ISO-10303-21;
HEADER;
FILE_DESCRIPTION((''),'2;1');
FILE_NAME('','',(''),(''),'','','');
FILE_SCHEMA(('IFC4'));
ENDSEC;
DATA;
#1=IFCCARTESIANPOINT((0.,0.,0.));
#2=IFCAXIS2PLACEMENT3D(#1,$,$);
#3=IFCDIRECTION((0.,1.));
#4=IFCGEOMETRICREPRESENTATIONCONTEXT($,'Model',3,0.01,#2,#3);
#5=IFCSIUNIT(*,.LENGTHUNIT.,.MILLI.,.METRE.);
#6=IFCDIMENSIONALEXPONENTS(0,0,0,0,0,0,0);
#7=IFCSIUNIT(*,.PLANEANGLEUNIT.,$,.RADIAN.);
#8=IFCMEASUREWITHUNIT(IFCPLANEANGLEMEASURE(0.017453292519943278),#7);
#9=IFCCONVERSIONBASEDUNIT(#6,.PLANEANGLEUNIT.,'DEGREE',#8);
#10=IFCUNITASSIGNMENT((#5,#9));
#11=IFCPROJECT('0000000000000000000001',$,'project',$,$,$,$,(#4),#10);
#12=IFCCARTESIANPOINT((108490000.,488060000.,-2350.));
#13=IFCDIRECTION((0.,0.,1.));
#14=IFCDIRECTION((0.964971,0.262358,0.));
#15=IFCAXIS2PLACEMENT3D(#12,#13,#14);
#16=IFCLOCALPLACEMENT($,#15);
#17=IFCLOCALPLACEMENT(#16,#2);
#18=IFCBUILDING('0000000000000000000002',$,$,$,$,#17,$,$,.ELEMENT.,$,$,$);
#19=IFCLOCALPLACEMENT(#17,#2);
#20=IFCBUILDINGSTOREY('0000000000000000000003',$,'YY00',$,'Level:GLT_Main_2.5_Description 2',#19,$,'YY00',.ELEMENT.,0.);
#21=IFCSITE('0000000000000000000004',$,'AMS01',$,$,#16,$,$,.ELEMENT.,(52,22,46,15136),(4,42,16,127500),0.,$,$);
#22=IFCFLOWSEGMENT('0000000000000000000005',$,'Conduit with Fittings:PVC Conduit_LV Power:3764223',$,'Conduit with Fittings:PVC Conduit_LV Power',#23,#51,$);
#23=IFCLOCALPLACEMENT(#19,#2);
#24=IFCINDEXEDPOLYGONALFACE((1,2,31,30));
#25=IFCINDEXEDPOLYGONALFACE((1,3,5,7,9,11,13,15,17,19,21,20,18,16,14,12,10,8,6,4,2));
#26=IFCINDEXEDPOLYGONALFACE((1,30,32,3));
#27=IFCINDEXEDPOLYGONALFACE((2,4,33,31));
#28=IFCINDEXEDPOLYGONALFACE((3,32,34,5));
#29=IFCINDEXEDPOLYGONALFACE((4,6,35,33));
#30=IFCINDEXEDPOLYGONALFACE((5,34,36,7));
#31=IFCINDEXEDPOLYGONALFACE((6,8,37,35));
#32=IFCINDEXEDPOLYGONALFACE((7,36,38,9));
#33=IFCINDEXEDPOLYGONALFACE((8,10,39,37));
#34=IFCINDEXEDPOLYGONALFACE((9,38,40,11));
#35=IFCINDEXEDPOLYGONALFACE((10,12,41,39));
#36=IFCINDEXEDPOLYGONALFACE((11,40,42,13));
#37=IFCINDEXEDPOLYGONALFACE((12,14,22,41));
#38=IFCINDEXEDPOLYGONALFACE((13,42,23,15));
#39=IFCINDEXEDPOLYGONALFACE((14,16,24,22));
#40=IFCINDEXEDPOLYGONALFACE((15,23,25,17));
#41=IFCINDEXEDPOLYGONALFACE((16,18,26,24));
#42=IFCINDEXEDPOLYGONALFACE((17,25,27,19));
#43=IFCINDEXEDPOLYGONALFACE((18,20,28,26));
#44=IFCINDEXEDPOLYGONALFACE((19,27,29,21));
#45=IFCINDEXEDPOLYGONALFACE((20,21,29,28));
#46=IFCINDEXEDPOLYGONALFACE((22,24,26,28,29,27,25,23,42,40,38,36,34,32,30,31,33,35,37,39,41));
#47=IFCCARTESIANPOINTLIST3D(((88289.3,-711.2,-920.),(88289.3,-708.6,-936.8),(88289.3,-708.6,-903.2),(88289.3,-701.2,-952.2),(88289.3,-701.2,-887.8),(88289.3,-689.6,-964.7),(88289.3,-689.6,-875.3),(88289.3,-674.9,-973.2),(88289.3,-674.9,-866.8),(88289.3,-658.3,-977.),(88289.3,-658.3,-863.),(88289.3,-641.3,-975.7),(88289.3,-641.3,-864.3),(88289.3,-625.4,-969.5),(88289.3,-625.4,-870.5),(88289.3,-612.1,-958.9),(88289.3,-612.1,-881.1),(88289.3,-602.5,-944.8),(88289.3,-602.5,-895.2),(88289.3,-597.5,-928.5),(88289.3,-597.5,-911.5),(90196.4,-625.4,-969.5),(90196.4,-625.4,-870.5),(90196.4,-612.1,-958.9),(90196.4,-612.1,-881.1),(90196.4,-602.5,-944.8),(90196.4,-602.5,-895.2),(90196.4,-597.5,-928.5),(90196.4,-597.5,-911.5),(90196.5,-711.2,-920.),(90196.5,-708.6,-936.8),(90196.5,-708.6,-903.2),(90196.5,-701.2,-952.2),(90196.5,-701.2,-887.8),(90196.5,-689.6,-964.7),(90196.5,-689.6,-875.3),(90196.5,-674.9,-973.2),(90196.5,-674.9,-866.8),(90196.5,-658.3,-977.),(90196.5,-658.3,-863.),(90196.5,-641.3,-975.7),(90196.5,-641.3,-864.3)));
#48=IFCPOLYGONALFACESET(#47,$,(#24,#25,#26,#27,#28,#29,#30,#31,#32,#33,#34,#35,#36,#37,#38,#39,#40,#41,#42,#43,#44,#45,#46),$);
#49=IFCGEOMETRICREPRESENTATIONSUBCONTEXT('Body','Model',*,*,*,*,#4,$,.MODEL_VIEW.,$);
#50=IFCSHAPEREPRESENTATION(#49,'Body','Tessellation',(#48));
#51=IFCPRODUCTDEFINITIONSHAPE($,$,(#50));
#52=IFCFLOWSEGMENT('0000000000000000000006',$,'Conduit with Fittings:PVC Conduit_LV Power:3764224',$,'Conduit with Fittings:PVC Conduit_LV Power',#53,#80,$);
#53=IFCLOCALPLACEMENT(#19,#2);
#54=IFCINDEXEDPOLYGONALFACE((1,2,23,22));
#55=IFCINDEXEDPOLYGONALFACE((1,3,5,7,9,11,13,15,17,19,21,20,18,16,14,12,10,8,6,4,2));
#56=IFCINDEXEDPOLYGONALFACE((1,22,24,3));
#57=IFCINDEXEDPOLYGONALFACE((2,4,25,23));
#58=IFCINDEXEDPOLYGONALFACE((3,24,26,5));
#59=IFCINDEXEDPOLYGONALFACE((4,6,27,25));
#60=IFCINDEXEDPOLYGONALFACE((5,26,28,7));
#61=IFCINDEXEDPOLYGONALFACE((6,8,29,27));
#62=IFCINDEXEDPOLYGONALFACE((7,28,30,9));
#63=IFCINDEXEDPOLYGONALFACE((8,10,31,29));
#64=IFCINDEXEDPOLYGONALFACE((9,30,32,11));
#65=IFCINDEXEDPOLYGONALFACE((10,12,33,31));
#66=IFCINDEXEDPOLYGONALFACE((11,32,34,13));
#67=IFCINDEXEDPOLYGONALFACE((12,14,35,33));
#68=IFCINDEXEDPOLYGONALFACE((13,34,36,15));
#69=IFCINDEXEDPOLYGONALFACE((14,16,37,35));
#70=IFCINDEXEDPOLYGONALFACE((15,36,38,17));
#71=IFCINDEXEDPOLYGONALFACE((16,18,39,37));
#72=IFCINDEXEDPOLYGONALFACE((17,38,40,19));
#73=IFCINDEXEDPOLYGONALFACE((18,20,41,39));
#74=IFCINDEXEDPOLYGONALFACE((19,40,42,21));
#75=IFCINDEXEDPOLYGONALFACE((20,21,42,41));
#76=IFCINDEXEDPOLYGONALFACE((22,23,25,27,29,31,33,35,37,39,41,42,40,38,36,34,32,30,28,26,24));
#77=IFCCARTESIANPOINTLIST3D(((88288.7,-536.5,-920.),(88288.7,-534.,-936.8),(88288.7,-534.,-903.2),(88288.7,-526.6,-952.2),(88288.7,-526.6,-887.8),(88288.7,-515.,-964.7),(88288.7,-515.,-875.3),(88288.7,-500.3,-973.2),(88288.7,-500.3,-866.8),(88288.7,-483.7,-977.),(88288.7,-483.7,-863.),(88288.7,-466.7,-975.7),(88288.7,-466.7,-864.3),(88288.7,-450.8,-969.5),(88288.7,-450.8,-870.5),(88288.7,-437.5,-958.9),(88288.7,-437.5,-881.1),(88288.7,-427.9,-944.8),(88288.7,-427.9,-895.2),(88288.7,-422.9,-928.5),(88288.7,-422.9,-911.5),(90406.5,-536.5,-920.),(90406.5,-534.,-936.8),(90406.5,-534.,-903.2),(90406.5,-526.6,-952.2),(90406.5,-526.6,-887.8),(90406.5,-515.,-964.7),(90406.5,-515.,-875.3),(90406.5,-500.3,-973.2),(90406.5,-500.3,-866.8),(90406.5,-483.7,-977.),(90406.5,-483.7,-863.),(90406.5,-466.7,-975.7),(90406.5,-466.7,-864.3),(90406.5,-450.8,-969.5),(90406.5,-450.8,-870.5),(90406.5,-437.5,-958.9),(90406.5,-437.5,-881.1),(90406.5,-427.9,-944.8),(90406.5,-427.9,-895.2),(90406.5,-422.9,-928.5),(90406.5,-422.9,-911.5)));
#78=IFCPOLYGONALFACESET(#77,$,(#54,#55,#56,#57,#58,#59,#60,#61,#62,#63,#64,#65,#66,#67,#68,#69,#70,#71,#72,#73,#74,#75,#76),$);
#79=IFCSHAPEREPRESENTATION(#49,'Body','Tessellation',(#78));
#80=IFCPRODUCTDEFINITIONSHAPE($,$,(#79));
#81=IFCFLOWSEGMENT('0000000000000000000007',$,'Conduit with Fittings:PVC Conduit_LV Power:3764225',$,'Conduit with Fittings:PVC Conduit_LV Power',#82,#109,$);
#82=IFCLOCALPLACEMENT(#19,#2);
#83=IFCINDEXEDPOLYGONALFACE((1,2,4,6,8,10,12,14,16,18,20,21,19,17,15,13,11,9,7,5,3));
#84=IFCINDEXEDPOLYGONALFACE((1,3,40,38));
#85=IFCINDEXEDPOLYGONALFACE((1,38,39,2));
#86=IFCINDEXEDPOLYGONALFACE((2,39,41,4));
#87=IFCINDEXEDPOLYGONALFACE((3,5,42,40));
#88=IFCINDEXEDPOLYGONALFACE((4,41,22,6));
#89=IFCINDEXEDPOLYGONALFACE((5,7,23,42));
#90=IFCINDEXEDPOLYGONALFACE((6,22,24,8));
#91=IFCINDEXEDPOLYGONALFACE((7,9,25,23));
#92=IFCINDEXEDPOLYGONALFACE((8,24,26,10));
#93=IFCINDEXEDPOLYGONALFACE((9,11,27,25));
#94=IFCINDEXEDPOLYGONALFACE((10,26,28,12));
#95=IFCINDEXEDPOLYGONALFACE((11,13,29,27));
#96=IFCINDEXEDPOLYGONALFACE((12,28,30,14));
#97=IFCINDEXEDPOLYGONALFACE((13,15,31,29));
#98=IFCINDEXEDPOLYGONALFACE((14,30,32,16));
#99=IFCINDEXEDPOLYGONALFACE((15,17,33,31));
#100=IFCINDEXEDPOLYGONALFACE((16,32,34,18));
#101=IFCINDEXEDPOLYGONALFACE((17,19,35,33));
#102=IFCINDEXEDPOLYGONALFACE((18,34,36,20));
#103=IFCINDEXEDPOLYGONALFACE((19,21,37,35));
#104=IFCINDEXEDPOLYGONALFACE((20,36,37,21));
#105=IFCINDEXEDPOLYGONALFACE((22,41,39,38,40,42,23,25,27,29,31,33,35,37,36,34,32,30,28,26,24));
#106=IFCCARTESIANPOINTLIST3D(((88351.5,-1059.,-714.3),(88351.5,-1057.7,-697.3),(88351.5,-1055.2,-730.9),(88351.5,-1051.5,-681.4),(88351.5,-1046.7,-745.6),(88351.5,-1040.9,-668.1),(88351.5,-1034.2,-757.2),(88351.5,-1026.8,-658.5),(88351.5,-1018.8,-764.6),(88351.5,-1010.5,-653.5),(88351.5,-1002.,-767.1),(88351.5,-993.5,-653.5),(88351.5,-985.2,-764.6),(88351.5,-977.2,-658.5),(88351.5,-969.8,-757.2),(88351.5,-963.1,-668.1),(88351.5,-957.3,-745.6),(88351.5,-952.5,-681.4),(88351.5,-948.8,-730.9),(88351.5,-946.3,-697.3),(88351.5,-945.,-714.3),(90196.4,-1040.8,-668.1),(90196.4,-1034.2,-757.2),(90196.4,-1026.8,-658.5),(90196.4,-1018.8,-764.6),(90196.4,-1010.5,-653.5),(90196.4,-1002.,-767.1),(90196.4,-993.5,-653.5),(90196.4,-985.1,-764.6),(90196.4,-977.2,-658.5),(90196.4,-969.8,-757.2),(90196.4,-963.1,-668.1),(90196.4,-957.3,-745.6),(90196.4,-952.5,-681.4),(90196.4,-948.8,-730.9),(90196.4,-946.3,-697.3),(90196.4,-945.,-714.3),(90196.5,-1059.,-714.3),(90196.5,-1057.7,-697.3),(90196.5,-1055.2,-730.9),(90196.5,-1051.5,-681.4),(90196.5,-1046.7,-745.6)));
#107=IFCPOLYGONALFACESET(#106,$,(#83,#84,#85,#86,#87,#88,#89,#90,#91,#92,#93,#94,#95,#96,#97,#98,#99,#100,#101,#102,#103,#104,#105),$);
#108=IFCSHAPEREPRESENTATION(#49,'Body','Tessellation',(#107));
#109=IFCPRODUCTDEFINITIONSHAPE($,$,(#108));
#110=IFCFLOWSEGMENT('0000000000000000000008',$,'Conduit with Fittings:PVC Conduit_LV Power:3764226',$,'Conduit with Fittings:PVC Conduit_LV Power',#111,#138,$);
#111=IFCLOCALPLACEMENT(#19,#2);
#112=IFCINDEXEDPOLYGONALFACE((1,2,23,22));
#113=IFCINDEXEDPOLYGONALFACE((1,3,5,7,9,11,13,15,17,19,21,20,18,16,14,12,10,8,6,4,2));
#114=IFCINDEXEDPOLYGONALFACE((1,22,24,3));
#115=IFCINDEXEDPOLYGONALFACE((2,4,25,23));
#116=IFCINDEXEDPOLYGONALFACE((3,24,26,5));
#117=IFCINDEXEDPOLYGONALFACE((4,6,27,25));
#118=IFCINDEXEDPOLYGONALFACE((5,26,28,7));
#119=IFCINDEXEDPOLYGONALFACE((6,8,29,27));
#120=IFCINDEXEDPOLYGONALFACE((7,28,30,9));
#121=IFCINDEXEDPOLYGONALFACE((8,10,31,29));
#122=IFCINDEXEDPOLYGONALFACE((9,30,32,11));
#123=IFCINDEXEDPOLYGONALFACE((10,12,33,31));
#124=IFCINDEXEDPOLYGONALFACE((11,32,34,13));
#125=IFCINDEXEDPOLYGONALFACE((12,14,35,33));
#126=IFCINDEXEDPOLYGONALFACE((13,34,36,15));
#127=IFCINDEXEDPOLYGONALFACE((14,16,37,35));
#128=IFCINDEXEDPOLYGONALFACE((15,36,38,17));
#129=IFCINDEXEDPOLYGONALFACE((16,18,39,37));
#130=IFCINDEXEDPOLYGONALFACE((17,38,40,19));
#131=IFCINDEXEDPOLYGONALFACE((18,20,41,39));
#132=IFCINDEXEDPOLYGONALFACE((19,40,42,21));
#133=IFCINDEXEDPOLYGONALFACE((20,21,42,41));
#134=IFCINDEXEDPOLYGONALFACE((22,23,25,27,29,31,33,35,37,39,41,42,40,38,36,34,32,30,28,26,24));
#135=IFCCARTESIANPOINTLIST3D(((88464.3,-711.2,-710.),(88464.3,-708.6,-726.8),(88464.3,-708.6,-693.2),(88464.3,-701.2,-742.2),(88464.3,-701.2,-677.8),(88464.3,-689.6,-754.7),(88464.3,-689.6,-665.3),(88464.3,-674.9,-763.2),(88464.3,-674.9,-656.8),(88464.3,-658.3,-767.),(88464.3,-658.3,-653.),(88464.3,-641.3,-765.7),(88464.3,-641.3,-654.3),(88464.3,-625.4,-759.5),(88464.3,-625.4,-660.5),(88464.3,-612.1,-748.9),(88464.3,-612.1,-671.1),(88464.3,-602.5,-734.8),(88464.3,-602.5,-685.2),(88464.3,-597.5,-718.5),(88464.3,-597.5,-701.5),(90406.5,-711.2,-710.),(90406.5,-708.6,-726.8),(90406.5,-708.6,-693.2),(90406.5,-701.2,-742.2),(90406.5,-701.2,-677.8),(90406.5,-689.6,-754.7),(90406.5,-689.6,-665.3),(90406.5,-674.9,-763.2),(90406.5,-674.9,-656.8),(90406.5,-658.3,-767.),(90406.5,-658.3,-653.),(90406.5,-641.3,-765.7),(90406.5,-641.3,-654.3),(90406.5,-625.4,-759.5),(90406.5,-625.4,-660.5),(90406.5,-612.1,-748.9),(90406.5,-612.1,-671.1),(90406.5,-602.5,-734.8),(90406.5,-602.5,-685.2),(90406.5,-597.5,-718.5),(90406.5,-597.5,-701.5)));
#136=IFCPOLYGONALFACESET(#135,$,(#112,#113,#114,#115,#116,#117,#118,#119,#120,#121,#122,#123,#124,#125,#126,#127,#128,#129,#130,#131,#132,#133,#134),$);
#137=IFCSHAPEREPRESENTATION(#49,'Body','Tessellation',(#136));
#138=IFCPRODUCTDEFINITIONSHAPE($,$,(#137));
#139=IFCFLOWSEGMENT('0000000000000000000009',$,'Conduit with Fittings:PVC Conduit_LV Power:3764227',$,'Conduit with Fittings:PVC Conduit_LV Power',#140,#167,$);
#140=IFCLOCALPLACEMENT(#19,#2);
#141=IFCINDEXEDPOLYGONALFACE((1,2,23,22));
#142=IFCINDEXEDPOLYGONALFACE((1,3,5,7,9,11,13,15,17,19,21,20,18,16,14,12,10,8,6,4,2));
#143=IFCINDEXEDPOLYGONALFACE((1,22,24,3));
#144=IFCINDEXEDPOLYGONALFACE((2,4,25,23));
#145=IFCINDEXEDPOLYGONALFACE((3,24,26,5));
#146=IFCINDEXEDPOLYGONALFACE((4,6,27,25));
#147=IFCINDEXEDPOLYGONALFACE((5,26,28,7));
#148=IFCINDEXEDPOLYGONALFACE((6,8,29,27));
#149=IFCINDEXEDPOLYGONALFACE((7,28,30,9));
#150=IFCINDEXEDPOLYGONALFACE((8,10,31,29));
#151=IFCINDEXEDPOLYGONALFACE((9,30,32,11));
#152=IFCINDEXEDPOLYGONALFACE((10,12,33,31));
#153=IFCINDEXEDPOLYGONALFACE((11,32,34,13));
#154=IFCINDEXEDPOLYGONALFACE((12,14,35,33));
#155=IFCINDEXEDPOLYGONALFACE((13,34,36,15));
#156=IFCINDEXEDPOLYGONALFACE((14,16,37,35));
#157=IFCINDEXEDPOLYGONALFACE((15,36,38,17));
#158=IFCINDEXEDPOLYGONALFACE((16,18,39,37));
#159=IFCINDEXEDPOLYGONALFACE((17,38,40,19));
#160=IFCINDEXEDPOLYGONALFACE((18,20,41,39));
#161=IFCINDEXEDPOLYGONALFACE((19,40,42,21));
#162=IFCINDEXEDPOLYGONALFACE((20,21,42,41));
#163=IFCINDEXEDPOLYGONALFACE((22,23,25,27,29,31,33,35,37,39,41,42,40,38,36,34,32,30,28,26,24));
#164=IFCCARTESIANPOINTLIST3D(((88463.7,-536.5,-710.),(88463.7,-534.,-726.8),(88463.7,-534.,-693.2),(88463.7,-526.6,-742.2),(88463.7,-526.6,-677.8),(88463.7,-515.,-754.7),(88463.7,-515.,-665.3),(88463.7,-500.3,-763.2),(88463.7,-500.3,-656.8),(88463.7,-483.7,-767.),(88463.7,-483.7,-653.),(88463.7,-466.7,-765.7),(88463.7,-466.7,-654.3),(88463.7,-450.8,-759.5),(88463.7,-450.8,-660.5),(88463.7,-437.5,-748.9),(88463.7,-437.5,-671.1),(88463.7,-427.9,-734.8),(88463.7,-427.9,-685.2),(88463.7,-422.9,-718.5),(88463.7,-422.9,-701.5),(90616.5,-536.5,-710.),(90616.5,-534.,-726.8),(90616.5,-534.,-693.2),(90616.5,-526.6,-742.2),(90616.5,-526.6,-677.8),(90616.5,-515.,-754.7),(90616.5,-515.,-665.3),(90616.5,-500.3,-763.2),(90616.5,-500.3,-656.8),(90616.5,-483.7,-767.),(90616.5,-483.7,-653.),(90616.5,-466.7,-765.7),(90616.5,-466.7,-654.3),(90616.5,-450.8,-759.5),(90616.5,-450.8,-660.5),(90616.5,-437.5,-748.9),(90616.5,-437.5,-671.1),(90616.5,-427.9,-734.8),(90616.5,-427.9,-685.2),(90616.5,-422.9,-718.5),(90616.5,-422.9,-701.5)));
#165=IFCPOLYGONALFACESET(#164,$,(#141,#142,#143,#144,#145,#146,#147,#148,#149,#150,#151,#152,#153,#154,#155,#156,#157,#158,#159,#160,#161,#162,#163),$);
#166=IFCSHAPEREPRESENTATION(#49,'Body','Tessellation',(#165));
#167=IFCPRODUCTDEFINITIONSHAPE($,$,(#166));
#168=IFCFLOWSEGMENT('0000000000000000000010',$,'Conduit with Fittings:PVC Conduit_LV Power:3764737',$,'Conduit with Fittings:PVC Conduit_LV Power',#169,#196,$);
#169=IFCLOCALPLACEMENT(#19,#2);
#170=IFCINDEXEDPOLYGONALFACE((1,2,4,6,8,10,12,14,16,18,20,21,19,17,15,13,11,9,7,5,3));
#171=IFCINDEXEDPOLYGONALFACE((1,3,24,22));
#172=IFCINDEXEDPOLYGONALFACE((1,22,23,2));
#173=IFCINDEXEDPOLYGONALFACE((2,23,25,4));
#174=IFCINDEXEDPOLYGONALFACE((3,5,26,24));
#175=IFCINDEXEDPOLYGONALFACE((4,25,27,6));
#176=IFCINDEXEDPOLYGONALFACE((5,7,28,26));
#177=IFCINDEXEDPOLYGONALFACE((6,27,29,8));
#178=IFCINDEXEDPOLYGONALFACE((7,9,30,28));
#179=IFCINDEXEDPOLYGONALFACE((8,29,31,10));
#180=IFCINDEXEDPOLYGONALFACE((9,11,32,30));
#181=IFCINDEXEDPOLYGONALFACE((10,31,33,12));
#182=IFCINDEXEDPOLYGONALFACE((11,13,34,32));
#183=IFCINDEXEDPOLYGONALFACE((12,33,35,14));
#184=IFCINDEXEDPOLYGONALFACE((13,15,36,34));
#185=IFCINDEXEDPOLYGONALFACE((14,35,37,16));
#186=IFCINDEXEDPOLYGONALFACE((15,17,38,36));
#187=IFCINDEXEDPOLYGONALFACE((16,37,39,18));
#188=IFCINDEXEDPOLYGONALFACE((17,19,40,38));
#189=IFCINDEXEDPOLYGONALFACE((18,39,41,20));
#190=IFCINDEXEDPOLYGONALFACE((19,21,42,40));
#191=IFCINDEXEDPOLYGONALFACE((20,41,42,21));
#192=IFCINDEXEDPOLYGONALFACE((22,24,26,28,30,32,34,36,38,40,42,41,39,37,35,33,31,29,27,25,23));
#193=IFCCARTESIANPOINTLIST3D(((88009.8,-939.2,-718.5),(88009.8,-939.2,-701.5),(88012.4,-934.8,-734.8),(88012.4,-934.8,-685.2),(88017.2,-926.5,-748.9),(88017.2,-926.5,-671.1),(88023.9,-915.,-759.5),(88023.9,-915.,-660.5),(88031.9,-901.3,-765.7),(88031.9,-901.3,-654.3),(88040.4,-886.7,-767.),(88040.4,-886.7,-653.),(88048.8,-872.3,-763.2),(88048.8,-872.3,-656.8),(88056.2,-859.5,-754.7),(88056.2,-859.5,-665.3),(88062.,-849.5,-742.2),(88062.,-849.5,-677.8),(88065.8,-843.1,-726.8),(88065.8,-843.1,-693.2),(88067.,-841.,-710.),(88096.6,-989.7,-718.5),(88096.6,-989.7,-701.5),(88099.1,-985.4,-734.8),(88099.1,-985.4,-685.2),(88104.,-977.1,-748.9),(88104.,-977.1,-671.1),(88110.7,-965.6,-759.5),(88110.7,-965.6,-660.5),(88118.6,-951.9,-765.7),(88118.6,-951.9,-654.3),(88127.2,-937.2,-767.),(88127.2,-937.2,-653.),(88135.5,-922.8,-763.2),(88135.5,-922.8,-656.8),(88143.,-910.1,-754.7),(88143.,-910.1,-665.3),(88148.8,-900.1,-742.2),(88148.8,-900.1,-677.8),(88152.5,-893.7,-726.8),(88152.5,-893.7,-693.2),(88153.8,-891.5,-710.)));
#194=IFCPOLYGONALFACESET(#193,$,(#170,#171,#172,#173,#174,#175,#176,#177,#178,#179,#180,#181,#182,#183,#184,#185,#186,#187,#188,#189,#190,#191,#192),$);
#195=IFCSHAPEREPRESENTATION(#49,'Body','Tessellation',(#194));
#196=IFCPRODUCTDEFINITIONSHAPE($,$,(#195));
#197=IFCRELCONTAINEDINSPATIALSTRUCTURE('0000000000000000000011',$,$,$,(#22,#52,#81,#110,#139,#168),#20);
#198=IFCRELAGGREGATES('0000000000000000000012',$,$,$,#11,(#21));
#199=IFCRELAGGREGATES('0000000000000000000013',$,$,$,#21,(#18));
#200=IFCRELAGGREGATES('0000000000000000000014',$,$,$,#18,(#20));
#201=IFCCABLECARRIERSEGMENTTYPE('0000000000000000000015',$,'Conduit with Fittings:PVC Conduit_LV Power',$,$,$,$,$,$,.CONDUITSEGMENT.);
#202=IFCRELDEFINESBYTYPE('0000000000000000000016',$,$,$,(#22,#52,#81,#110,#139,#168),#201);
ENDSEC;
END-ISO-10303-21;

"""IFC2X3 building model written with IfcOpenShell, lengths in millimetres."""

from ifc_helpers import new_model, entity, si_unit, converted_unit, direction, frame, frame_2d, origin, place, context, subcontext, project, spatial, circle, extrude, type_object, element, save


model = new_model("IFC2X3")

# Units and contexts
model_context = context("Model", 3, precision=0.01, world=origin(), true_north=direction((0.0, 1.0)))
body_context = subcontext(model_context, "Body", "Model", "MODEL_VIEW")
ifc_project = project(units=[si_unit("LENGTHUNIT", "METRE", prefix="MILLI"), converted_unit("PLANEANGLEUNIT", "DEGREE", entity("IfcPlaneAngleMeasure", 0.017453292519943278), si_unit("PLANEANGLEUNIT", "RADIAN"), dimensions=[0, 0, 0, 0, 0, 0, 0])], contexts=[model_context])

# Site, building, storey
site_placement = place(None, frame((108490000.0, 488060000.0, -2350.0), z_axis=(0.0, 0.0, 1.0), x_axis=(0.964971, 0.262358, 0.0)))
site = spatial("IfcSite", under=ifc_project, at=site_placement, Name="AMS01", CompositionType="ELEMENT", RefLatitude=(52, 22, 46, 15136), RefLongitude=(4, 42, 16, 127500), RefElevation=0.0)
building_placement = place(site_placement, origin())
building = spatial("IfcBuilding", under=site, at=building_placement, CompositionType="ELEMENT")
storey_placement = place(building_placement, origin())
storey = spatial("IfcBuildingStorey", under=building, at=storey_placement, Name="YY00", ObjectType="Level:GLT_Main_2.5_Description 2", LongName="YY00", CompositionType="ELEMENT", Elevation=0.0)

# Flow segments
cable_carrier_segment_type = type_object("IfcCableCarrierSegmentType", Name="Conduit with Fittings:PVC Conduit_LV Power", PredefinedType="CONDUITSEGMENT")
flow_segment_1_placement = place(storey_placement, origin())
element("IfcFlowSegment", 1, at=flow_segment_1_placement, inside=storey, type_object=cable_carrier_segment_type, Name="Conduit with Fittings:PVC Conduit_LV Power:3764223", ObjectType="Conduit with Fittings:PVC Conduit_LV Power", context=body_context, shape_type="SweptSolid", body=[
    extrude(circle(Radius=57.2, at=frame_2d((0.0, 0.0), x_axis=(1.0, 0.0))), frame((88289.3, -654.0, -920.0), z_axis=(1.0, 0.000004, 0.0), x_axis=(0.000004, -1.0, 0.0)), (0.0, 0.0, 1.0), 1907.1),
])
flow_segment_2_placement = place(storey_placement, origin())
element("IfcFlowSegment", 2, at=flow_segment_2_placement, inside=storey, type_object=cable_carrier_segment_type, Name="Conduit with Fittings:PVC Conduit_LV Power:3764224", ObjectType="Conduit with Fittings:PVC Conduit_LV Power", context=body_context, shape_type="SweptSolid", body=[
    extrude(circle(Radius=57.2, at=frame_2d((0.0, 0.0), x_axis=(1.0, 0.0))), frame((88288.7, -479.4, -920.0), z_axis=(1.0, 0.0, 0.0), x_axis=(0.0, -1.0, 0.0)), (0.0, 0.0, 1.0), 2117.8),
])
flow_segment_3_placement = place(storey_placement, origin())
element("IfcFlowSegment", 3, at=flow_segment_3_placement, inside=storey, type_object=cable_carrier_segment_type, Name="Conduit with Fittings:PVC Conduit_LV Power:3764225", ObjectType="Conduit with Fittings:PVC Conduit_LV Power", context=body_context, shape_type="SweptSolid", body=[
    extrude(circle(Radius=57.1, at=frame_2d((0.0, 0.0), x_axis=(1.0, 0.0))), frame((88351.5, -1002.0, -710.0), z_axis=(1.0, 0.000012, 0.0), x_axis=(0.0, 0.0, -1.0)), (0.0, 0.0, 1.0), 1845.0),
])
flow_segment_4_placement = place(storey_placement, origin())
element("IfcFlowSegment", 4, at=flow_segment_4_placement, inside=storey, type_object=cable_carrier_segment_type, Name="Conduit with Fittings:PVC Conduit_LV Power:3764226", ObjectType="Conduit with Fittings:PVC Conduit_LV Power", context=body_context, shape_type="SweptSolid", body=[
    extrude(circle(Radius=57.2, at=frame_2d((0.0, 0.0), x_axis=(1.0, 0.0))), frame((88464.3, -654.0, -710.0), z_axis=(1.0, 0.0, 0.0), x_axis=(0.0, -1.0, 0.0)), (0.0, 0.0, 1.0), 1942.1),
])
flow_segment_5_placement = place(storey_placement, origin())
element("IfcFlowSegment", 5, at=flow_segment_5_placement, inside=storey, type_object=cable_carrier_segment_type, Name="Conduit with Fittings:PVC Conduit_LV Power:3764227", ObjectType="Conduit with Fittings:PVC Conduit_LV Power", context=body_context, shape_type="SweptSolid", body=[
    extrude(circle(Radius=57.2, at=frame_2d((0.0, 0.0), x_axis=(1.0, 0.0))), frame((88463.7, -479.4, -710.0), z_axis=(1.0, 0.0, 0.0), x_axis=(0.0, -1.0, 0.0)), (0.0, 0.0, 1.0), 2152.8),
])
flow_segment_6_placement = place(storey_placement, origin())
element("IfcFlowSegment", 6, at=flow_segment_6_placement, inside=storey, type_object=cable_carrier_segment_type, Name="Conduit with Fittings:PVC Conduit_LV Power:3764737", ObjectType="Conduit with Fittings:PVC Conduit_LV Power", context=body_context, shape_type="SweptSolid", body=[
    extrude(circle(Radius=57.2, at=frame_2d((0.0, 0.0), x_axis=(1.0, 0.0))), frame((88125.0, -940.9, -710.0), z_axis=(-0.864153, 0.503229, 0.0), x_axis=(0.503229, 0.864153, 0.0)), (0.0, 0.0, 1.0), 100.4),
])

save(model, "model.ifc")
